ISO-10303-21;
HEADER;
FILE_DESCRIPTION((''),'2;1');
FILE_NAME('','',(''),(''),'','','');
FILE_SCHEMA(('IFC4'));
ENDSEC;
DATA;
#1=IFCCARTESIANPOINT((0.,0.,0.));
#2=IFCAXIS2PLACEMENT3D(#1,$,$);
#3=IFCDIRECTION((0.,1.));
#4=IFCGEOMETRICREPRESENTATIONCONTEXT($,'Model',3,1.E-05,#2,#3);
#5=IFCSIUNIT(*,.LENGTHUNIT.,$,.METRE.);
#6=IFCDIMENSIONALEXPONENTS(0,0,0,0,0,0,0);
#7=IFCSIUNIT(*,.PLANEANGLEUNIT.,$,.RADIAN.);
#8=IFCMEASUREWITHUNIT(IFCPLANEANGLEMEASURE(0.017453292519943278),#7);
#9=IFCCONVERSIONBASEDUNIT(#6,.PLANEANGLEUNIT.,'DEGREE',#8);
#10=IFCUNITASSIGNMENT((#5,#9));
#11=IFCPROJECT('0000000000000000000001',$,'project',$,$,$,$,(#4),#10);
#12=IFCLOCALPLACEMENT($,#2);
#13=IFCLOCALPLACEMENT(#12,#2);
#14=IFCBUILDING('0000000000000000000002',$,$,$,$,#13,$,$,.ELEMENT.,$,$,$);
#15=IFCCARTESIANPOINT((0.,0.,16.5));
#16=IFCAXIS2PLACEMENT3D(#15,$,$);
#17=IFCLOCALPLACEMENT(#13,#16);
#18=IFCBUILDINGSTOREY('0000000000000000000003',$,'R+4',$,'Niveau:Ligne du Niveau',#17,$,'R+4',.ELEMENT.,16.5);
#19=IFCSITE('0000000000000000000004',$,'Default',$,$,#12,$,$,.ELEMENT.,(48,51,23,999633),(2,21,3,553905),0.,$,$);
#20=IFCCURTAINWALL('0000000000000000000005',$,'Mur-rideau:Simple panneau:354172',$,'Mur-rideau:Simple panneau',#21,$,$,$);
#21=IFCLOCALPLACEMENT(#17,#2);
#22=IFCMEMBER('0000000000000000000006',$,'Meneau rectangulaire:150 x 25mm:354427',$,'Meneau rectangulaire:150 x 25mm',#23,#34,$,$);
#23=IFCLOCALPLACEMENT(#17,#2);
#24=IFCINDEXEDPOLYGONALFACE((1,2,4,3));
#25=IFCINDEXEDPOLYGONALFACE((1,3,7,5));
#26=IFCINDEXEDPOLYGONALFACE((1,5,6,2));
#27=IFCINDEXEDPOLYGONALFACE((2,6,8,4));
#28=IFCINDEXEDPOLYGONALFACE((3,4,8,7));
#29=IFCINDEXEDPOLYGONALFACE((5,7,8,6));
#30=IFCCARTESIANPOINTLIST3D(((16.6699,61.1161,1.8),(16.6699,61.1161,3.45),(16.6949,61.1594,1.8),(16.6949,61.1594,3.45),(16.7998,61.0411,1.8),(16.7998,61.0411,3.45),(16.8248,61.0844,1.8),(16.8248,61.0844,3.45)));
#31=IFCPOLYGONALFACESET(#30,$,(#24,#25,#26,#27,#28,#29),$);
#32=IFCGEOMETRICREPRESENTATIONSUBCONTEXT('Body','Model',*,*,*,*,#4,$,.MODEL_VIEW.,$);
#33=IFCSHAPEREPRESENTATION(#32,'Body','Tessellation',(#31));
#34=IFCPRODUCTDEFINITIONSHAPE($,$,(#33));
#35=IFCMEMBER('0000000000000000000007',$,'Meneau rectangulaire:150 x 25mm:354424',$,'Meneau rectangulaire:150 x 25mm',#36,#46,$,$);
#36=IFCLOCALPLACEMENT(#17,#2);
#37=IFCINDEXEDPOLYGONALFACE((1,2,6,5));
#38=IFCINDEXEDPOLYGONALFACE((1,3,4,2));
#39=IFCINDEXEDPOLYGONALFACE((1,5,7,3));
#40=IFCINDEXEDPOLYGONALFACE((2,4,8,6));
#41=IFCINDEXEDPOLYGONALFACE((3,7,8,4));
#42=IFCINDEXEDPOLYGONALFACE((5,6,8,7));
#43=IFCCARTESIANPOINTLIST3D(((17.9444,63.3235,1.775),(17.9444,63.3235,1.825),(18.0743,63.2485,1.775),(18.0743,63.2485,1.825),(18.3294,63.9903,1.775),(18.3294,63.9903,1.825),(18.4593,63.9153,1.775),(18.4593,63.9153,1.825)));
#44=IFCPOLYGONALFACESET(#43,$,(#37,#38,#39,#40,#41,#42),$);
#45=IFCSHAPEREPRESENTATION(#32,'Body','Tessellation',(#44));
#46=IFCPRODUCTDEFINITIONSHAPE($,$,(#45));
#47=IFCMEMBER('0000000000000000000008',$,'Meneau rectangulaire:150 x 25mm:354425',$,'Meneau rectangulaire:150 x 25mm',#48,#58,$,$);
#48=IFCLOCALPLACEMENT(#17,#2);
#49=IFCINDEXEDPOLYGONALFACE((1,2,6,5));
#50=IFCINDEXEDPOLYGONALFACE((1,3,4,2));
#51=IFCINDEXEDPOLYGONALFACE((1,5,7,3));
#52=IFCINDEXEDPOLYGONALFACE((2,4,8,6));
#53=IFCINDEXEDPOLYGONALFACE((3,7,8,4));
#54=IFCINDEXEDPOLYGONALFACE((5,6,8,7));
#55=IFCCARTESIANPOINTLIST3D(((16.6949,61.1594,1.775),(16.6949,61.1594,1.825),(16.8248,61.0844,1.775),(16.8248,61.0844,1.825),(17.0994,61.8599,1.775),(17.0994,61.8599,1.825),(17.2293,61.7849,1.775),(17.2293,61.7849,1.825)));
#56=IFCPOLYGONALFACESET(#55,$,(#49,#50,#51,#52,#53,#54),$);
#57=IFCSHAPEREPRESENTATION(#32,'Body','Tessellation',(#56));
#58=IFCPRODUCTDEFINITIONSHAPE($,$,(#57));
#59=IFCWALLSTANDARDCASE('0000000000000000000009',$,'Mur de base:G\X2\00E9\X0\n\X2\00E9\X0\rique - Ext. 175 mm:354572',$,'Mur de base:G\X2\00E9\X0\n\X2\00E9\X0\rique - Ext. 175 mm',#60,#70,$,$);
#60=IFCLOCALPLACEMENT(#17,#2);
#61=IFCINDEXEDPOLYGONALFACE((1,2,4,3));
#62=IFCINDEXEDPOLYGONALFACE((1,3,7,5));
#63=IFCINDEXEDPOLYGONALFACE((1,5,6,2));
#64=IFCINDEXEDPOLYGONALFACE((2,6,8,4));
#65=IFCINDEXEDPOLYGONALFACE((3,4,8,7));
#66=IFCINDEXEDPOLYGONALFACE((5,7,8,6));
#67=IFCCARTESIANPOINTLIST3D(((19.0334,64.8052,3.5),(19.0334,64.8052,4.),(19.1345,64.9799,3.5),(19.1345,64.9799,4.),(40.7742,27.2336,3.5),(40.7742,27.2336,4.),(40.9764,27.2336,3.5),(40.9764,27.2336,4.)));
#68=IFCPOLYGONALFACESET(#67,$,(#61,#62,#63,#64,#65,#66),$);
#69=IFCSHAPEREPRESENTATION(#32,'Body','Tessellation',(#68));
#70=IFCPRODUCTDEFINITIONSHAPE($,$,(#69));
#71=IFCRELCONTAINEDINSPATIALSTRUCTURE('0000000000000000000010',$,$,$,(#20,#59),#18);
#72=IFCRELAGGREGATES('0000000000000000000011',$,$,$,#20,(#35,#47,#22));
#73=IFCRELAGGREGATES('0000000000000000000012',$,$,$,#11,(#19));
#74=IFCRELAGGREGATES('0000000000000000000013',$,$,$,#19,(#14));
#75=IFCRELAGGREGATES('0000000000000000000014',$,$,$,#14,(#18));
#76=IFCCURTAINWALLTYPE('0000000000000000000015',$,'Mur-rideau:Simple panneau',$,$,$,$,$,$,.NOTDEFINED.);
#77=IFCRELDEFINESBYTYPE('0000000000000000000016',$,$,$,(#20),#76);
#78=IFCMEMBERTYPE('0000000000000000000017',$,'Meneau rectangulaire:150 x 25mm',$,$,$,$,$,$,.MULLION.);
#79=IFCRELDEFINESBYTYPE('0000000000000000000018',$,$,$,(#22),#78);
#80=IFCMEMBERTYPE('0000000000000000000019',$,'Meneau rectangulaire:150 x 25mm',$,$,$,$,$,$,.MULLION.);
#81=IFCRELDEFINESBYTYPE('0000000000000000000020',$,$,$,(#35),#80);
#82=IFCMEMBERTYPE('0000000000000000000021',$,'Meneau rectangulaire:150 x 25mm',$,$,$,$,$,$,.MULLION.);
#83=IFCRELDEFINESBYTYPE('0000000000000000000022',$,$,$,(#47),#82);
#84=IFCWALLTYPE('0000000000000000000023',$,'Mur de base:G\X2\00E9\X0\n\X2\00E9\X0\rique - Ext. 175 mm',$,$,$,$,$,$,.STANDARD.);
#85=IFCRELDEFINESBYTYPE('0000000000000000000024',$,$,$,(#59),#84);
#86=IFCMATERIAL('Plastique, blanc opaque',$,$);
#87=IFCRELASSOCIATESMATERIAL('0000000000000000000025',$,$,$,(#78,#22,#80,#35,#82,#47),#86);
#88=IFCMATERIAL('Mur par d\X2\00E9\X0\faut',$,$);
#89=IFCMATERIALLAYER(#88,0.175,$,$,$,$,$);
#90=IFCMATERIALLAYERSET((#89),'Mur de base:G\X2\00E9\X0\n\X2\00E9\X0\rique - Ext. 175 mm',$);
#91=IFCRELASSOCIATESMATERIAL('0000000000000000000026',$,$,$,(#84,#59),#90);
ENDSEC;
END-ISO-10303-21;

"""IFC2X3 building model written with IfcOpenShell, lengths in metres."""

from ifc_helpers import new_model, entity, si_unit, converted_unit, direction, frame, origin, origin_2d_with_axis, place, context, subcontext, project, spatial, polyline, rectangle, outline, extrude, source, transform, mapped, material, layer, layer_set, layer_usage, type_object, type_shapes, element, aggregate, save


model = new_model("IFC2X3")

# Units and contexts
model_context = context("Model", 3, precision=1e-05, world=origin(), true_north=direction((0.0, 1.0)))
body_context = subcontext(model_context, "Body", "Model", "MODEL_VIEW")
ifc_project = project(units=[si_unit("LENGTHUNIT", "METRE"), converted_unit("PLANEANGLEUNIT", "DEGREE", entity("IfcPlaneAngleMeasure", 0.017453292519943278), si_unit("PLANEANGLEUNIT", "RADIAN"), dimensions=[0, 0, 0, 0, 0, 0, 0])], contexts=[model_context])

# Site, building, storey
site_placement = place(None, origin())
site = spatial("IfcSite", under=ifc_project, at=site_placement, Name="Default", CompositionType="ELEMENT", RefLatitude=(48, 51, 23, 999633), RefLongitude=(2, 21, 3, 553905), RefElevation=0.0)
building_placement = place(site_placement, origin())
building = spatial("IfcBuilding", under=site, at=building_placement, CompositionType="ELEMENT")
storey_placement = place(building_placement, frame((0.0, 0.0, 16.5)))
storey = spatial("IfcBuildingStorey", under=building, at=storey_placement, Name="R+4", ObjectType="Niveau:Ligne du Niveau", LongName="R+4", CompositionType="ELEMENT", Elevation=16.5)

# Curtain wall, members
curtain_wall_type = type_object("IfcCurtainWallType", Name="Mur-rideau:Simple panneau", PredefinedType="NOTDEFINED")
curtain_wall_placement = place(storey_placement, frame((0.0, 0.0, -16.5)))
curtain_wall = element("IfcCurtainWall", 1, at=curtain_wall_placement, inside=storey, type_object=curtain_wall_type, Name="Mur-rideau:Simple panneau:354172", ObjectType="Mur-rideau:Simple panneau")
ifc_material_1 = material(Name="Plastique, blanc opaque")
member_type_1 = type_object("IfcMemberType", Name="Meneau rectangulaire:150 x 25mm", PredefinedType="MULLION", material=ifc_material_1)
shared_shape_1 = source(origin(), body_context, "Body", "SweptSolid", [
    extrude(rectangle(XDim=0.05, YDim=0.15, at=origin_2d_with_axis()), frame((0.0, 0.0, -1.65), z_axis=(0.0, 0.0, 1.0), x_axis=(-1.0, 0.0, 0.0)), (0.0, 0.0, 1.0), 1.65),
])
type_shapes(member_type_1, [shared_shape_1])
member_1_placement = place(curtain_wall_placement, frame((16.7474, 61.1002, 18.3), z_axis=(0.0, 0.0, -1.0), x_axis=(-0.5, -0.866025, 0.0)))
member_1 = element("IfcMember", 2, at=member_1_placement, type_object=member_type_1, material=ifc_material_1, Name="Meneau rectangulaire:150 x 25mm:354427", ObjectType="Meneau rectangulaire:150 x 25mm", context=body_context, shape_type="MappedRepresentation", body=[
    mapped(shared_shape_1, transform((0.0, 0.0, 0.0), scale=1.0)),
])
member_type_2 = type_object("IfcMemberType", Name="Meneau rectangulaire:150 x 25mm", PredefinedType="MULLION", material=ifc_material_1)
shared_shape_2 = source(origin(), body_context, "Body", "SweptSolid", [
    extrude(rectangle(XDim=0.05, YDim=0.15, at=origin_2d_with_axis()), frame((0.0, 0.0, -0.77), z_axis=(0.0, 0.0, 1.0), x_axis=(-1.0, 0.0, 0.0)), (0.0, 0.0, 1.0), 0.77),
])
type_shapes(member_type_2, [shared_shape_2])
member_2_placement = place(curtain_wall_placement, frame((18.0093, 63.286, 18.3), z_axis=(-0.5, -0.866025, 0.0), x_axis=(0.0, 0.0, 1.0)))
member_2 = element("IfcMember", 3, at=member_2_placement, type_object=member_type_2, material=ifc_material_1, Name="Meneau rectangulaire:150 x 25mm:354424", ObjectType="Meneau rectangulaire:150 x 25mm", context=body_context, shape_type="MappedRepresentation", body=[
    mapped(shared_shape_2, transform((0.0, 0.0, 0.0), scale=1.0)),
])
member_type_3 = type_object("IfcMemberType", Name="Meneau rectangulaire:150 x 25mm", PredefinedType="MULLION", material=ifc_material_1)
shared_shape_3 = source(origin(), body_context, "Body", "SweptSolid", [
    extrude(rectangle(XDim=0.05, YDim=0.15, at=origin_2d_with_axis()), frame((0.0, 0.0, -0.8089), z_axis=(0.0, 0.0, 1.0), x_axis=(-1.0, 0.0, 0.0)), (0.0, 0.0, 1.0), 0.8089),
])
type_shapes(member_type_3, [shared_shape_3])
member_3_placement = place(curtain_wall_placement, frame((16.7599, 61.1219, 18.3), z_axis=(-0.5, -0.866025, 0.0), x_axis=(0.0, 0.0, 1.0)))
member_3 = element("IfcMember", 4, at=member_3_placement, type_object=member_type_3, material=ifc_material_1, Name="Meneau rectangulaire:150 x 25mm:354425", ObjectType="Meneau rectangulaire:150 x 25mm", context=body_context, shape_type="MappedRepresentation", body=[
    mapped(shared_shape_3, transform((0.0, 0.0, 0.0), scale=1.0)),
])
aggregate(curtain_wall, [member_2, member_3, member_1])

# Wall
ifc_material_2 = material(Name="Mur par défaut")
ifc_layer_1 = layer(ifc_material_2, 0.175)
ifc_layer_set_1 = layer_set([ifc_layer_1], Name="Mur de base:Générique - Ext. 175 mm")
ifc_layer_usage = layer_usage(ifc_layer_set_1, "AXIS2", "POSITIVE", -0.0875)
wall_type = type_object("IfcWallType", Name="Mur de base:Générique - Ext. 175 mm", PredefinedType="STANDARD", material=ifc_layer_set_1)
wall_placement = place(storey_placement, frame((19.0588, 64.9361, 3.5), z_axis=(0.0, 0.0, 1.0), x_axis=(0.500842, -0.865539, 0.0)))
element("IfcWallStandardCase", 5, at=wall_placement, inside=storey, type_object=wall_type, material=ifc_layer_usage, Name="Mur de base:Générique - Ext. 175 mm:354572", ObjectType="Mur de base:Générique - Ext. 175 mm", context=body_context, shape_type="SweptSolid", body=[
    extrude(outline(polyline([(43.5089, -0.0875), (43.6102, 0.0875), (0.0, 0.0875), (0.1006, -0.0875), (43.5089, -0.0875)])), origin(), (0.0, 0.0, 1.0), 0.5),
])

save(model, "model.ifc")
